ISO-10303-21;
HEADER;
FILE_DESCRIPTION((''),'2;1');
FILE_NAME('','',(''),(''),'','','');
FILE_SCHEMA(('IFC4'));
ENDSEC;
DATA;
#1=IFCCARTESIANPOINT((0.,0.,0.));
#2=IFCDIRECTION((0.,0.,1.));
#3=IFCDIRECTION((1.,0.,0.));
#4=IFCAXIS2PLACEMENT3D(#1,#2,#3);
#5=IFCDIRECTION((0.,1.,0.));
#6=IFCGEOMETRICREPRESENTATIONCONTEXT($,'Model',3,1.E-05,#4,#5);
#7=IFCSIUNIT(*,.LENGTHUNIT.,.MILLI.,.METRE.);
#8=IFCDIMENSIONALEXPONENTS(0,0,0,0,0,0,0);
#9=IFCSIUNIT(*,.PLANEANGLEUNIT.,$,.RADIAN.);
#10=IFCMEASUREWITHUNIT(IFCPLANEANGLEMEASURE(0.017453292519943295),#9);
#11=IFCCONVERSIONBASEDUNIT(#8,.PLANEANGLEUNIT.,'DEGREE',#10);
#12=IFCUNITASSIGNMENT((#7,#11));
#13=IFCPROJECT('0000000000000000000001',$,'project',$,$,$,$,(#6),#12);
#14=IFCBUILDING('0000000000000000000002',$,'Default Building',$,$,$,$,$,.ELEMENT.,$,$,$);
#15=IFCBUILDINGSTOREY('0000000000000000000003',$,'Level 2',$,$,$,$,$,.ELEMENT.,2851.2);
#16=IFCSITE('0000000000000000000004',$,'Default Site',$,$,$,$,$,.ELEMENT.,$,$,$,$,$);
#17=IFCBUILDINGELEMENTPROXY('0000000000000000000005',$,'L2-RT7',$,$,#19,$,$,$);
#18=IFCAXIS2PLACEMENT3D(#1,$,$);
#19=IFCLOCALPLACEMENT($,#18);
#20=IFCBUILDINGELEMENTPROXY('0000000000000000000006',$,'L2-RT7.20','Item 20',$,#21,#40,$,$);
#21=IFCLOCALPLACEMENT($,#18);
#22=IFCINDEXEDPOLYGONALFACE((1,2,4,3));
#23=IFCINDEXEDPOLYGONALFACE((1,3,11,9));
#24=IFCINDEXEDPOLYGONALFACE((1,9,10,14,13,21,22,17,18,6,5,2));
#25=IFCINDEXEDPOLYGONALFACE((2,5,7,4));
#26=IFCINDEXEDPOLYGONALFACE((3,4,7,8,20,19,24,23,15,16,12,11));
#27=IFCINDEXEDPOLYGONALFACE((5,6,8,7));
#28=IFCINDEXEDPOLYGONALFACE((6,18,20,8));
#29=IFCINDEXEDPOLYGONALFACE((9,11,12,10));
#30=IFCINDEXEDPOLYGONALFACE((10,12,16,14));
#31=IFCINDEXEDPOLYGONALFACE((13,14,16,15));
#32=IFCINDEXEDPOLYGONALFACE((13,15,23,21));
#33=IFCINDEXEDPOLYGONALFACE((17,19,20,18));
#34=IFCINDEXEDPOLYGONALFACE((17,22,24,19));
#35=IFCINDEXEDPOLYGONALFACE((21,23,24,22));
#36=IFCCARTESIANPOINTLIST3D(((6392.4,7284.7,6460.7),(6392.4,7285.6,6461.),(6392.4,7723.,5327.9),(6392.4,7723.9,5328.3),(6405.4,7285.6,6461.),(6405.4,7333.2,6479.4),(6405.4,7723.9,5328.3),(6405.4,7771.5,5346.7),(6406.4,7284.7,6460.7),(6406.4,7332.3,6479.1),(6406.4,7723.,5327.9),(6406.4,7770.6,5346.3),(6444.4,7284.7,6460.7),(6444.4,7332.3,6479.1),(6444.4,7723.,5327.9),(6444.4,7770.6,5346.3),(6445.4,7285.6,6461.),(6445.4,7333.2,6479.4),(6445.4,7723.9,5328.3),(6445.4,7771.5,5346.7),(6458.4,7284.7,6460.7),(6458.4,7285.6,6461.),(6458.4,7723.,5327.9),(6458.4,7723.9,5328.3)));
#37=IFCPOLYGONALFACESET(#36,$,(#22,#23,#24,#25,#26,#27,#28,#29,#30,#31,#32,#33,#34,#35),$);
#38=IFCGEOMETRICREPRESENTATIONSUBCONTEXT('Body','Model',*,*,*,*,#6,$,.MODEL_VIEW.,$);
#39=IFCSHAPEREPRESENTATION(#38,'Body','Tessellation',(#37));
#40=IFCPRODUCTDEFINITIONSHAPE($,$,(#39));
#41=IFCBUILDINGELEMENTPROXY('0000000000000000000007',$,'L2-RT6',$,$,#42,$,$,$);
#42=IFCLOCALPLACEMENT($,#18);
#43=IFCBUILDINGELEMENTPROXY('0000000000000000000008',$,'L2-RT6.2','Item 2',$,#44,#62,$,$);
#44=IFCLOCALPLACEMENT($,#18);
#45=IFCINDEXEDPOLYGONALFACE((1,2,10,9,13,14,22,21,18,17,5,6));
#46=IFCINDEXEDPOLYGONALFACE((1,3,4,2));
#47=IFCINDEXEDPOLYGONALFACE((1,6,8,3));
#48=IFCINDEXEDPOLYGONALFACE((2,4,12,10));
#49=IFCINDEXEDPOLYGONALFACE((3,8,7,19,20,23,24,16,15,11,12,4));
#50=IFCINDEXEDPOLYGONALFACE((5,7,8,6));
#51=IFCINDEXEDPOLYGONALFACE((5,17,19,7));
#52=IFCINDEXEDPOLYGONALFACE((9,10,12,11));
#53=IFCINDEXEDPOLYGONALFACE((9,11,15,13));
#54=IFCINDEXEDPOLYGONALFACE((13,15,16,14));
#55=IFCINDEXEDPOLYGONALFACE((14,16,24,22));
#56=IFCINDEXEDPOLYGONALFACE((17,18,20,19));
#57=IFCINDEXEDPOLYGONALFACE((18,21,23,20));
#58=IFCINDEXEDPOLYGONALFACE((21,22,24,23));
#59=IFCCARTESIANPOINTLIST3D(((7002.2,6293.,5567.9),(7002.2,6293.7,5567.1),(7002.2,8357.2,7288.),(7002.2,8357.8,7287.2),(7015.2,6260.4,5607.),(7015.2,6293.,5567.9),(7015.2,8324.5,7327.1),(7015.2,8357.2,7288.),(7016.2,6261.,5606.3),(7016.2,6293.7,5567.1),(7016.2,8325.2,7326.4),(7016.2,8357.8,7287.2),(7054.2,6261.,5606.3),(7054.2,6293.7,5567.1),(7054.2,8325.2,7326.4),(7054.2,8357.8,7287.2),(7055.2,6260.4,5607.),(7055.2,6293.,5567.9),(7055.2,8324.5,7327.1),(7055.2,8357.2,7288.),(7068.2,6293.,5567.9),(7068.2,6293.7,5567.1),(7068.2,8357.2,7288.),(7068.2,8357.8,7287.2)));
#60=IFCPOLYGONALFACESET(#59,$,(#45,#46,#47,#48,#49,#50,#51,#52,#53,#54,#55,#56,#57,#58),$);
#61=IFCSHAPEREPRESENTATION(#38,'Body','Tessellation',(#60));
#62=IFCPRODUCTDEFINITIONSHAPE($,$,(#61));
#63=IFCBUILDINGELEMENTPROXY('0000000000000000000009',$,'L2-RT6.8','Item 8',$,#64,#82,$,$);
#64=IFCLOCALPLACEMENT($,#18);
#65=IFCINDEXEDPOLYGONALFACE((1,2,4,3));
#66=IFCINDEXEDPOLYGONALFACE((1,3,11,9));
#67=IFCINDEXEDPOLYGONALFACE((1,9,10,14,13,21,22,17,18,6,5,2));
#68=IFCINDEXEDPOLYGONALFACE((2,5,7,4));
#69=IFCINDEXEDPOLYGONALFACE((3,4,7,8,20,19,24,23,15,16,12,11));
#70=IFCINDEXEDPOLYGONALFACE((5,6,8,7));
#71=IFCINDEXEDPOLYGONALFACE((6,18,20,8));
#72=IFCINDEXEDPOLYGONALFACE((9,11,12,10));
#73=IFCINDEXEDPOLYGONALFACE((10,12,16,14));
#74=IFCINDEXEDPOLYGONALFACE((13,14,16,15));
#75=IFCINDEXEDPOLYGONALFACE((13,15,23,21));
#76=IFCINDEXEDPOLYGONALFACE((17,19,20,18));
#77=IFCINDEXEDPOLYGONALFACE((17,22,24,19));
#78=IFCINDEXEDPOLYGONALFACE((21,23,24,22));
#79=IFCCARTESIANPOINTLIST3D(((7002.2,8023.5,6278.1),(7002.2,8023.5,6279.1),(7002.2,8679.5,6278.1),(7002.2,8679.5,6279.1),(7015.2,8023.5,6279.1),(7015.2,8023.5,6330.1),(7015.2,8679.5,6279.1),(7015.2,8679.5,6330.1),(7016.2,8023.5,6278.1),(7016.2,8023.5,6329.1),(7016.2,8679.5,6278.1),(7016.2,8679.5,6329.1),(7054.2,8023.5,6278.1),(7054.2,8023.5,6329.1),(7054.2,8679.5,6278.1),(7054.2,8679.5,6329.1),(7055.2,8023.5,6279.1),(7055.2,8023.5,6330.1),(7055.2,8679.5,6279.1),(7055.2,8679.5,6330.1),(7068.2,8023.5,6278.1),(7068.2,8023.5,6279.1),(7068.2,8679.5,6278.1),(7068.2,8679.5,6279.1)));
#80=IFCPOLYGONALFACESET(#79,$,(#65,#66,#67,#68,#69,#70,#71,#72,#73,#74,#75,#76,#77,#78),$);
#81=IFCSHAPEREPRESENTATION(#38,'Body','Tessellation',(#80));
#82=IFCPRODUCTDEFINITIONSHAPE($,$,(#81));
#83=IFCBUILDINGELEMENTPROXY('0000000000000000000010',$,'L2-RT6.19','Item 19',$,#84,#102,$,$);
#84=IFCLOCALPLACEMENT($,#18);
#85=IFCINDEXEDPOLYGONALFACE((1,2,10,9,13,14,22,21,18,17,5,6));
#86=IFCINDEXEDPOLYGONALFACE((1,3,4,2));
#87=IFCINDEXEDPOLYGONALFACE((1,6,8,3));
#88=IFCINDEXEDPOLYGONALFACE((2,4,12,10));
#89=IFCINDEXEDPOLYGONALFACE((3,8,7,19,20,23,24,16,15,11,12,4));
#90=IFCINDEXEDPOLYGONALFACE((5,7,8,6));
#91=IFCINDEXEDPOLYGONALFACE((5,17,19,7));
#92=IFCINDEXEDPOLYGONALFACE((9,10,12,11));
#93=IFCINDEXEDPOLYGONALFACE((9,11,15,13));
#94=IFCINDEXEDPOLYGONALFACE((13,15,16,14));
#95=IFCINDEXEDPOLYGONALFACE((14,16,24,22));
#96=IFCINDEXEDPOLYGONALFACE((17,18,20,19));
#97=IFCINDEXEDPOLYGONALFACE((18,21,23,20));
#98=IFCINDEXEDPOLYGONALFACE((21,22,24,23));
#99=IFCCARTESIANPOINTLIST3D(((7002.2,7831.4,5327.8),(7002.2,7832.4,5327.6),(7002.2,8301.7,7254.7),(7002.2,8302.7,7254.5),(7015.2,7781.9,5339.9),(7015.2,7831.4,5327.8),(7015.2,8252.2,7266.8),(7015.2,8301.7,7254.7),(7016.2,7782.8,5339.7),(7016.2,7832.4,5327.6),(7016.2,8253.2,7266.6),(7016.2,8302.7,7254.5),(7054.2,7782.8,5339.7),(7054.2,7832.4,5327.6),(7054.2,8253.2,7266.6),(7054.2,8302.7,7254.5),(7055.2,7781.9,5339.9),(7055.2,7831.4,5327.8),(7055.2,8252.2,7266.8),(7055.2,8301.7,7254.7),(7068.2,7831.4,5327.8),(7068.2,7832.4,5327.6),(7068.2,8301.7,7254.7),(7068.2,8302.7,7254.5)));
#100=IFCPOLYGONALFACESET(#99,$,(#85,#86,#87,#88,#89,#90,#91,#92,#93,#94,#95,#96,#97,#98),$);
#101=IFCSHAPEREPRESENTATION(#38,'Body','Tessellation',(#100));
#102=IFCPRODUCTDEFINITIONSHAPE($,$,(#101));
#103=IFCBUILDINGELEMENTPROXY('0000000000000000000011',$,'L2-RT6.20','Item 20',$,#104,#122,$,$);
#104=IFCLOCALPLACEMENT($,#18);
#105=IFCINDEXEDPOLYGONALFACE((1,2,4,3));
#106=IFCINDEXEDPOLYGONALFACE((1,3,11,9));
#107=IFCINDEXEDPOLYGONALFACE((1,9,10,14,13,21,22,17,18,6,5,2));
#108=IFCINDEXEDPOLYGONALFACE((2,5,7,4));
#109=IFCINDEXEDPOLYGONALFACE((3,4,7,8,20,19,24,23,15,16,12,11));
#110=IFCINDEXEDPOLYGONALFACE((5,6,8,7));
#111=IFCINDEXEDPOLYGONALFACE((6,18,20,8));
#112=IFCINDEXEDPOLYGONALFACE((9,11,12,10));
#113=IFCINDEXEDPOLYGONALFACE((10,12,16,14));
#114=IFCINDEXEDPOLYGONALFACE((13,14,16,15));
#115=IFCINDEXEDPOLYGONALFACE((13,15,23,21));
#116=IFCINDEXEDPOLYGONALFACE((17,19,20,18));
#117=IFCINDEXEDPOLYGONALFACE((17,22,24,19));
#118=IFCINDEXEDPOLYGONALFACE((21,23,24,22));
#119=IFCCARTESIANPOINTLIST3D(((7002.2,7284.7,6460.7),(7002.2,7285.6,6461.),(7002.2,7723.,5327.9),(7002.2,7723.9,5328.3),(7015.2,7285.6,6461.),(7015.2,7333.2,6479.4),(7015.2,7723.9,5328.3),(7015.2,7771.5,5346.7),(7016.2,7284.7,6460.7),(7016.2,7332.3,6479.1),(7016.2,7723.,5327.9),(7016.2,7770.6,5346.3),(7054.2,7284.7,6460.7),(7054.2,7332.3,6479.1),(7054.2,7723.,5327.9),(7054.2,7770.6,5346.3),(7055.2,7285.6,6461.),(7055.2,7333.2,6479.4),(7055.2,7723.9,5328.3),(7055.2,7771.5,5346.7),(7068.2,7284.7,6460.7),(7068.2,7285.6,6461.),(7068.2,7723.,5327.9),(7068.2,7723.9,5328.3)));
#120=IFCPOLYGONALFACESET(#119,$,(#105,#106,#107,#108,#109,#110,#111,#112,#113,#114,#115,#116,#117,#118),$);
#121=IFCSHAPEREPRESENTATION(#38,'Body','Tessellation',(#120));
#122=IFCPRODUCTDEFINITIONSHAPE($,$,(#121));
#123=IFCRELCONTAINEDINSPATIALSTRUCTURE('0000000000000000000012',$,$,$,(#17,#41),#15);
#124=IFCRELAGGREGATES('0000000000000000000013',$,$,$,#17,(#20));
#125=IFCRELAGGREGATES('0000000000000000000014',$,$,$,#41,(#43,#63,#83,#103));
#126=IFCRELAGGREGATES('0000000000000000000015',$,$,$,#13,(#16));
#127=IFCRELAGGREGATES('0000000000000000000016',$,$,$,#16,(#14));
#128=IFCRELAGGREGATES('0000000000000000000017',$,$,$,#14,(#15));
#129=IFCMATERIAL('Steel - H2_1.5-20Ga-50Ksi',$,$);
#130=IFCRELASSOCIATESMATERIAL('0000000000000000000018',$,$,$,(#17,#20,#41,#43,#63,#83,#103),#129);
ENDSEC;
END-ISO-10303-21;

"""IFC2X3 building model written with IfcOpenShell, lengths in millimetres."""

from ifc_helpers import new_model, entity, si_unit, converted_unit, direction, frame, origin, origin_with_axes, place, context, subcontext, project, spatial, polyline, outline, extrude, material, element, aggregate, save


model = new_model("IFC2X3")

# Units and contexts
model_context = context("Model", 3, precision=1e-05, world=origin_with_axes(), true_north=direction((0.0, 1.0, 0.0)))
body_context = subcontext(model_context, "Body", "Model", "MODEL_VIEW")
ifc_project = project(units=[si_unit("LENGTHUNIT", "METRE", prefix="MILLI"), converted_unit("PLANEANGLEUNIT", "DEGREE", entity("IfcPlaneAngleMeasure", 0.017453292519943295), si_unit("PLANEANGLEUNIT", "RADIAN"), dimensions=[0, 0, 0, 0, 0, 0, 0])], contexts=[model_context])

# Site, building, storey
site = spatial("IfcSite", under=ifc_project, Name="Default Site", CompositionType="ELEMENT")
building = spatial("IfcBuilding", under=site, Name="Default Building", CompositionType="ELEMENT")
storey = spatial("IfcBuildingStorey", under=building, Name="Level 2", CompositionType="ELEMENT", Elevation=2851.2)

# Building element proxies
ifc_material_1 = material(Name="Steel - H2_1.5-20Ga-50Ksi")
proxy_1 = element("IfcBuildingElementProxy", 1, inside=storey, material=ifc_material_1, Name="L2-RT7")
proxy_2_placement = place(None, frame((6392.4, 7723.0, 5327.9), z_axis=(0.0, -0.361, 0.933), x_axis=(40.0, 0.0, 0.0)))
proxy_2 = element("IfcBuildingElementProxy", 2, at=proxy_2_placement, material=ifc_material_1, Name="L2-RT7.20", Description="Item 20", context=body_context, shape_type="SweptSolid", body=[
    extrude(outline(polyline([(0.0, 0.0), (14.0, 0.0), (14.0, 51.0), (52.0, 51.0), (52.0, 0.0), (66.0, 0.0), (66.0, 1.0), (53.0, 1.0), (53.0, 52.0), (13.0, 52.0), (13.0, 1.0), (0.0, 1.0), (0.0, 0.0)])), origin(), (0.0, 0.0, 1.0), 1214.6),
])
aggregate(proxy_1, [proxy_2])
proxy_3 = element("IfcBuildingElementProxy", 3, inside=storey, material=ifc_material_1, Name="L2-RT6")
proxy_4_placement = place(None, frame((7002.2, 8357.8, 7287.2), z_axis=(0.0, -0.768, -0.64), x_axis=(40.0, 0.0, 0.0)))
proxy_4 = element("IfcBuildingElementProxy", 4, at=proxy_4_placement, material=ifc_material_1, Name="L2-RT6.2", Description="Item 2", context=body_context, shape_type="SweptSolid", body=[
    extrude(outline(polyline([(0.0, 0.0), (14.0, 0.0), (14.0, 51.0), (52.0, 51.0), (52.0, 0.0), (66.0, 0.0), (66.0, 1.0), (53.0, 1.0), (53.0, 52.0), (13.0, 52.0), (13.0, 1.0), (0.0, 1.0), (0.0, 0.0)])), origin(), (0.0, 0.0, 1.0), 2686.9),
])
proxy_5_placement = place(None, frame((7002.2, 8679.5, 6278.1), z_axis=(0.0, -1.0, 0.0), x_axis=(40.0, 0.0, 0.0)))
proxy_5 = element("IfcBuildingElementProxy", 5, at=proxy_5_placement, material=ifc_material_1, Name="L2-RT6.8", Description="Item 8", context=body_context, shape_type="SweptSolid", body=[
    extrude(outline(polyline([(0.0, 0.0), (14.0, 0.0), (14.0, 51.0), (52.0, 51.0), (52.0, 0.0), (66.0, 0.0), (66.0, 1.0), (53.0, 1.0), (53.0, 52.0), (13.0, 52.0), (13.0, 1.0), (0.0, 1.0), (0.0, 0.0)])), origin(), (0.0, 0.0, 1.0), 656.0),
])
proxy_6_placement = place(None, frame((7002.2, 8302.7, 7254.5), z_axis=(0.0, -0.237, -0.971), x_axis=(40.0, 0.0, 0.0)))
proxy_6 = element("IfcBuildingElementProxy", 6, at=proxy_6_placement, material=ifc_material_1, Name="L2-RT6.19", Description="Item 19", context=body_context, shape_type="SweptSolid", body=[
    extrude(outline(polyline([(0.0, 0.0), (14.0, 0.0), (14.0, 51.0), (52.0, 51.0), (52.0, 0.0), (66.0, 0.0), (66.0, 1.0), (53.0, 1.0), (53.0, 52.0), (13.0, 52.0), (13.0, 1.0), (0.0, 1.0), (0.0, 0.0)])), origin(), (0.0, 0.0, 1.0), 1983.5),
])
proxy_7_placement = place(None, frame((7002.2, 7723.0, 5327.9), z_axis=(0.0, -0.361, 0.933), x_axis=(40.0, 0.0, 0.0)))
proxy_7 = element("IfcBuildingElementProxy", 7, at=proxy_7_placement, material=ifc_material_1, Name="L2-RT6.20", Description="Item 20", context=body_context, shape_type="SweptSolid", body=[
    extrude(outline(polyline([(0.0, 0.0), (14.0, 0.0), (14.0, 51.0), (52.0, 51.0), (52.0, 0.0), (66.0, 0.0), (66.0, 1.0), (53.0, 1.0), (53.0, 52.0), (13.0, 52.0), (13.0, 1.0), (0.0, 1.0), (0.0, 0.0)])), origin(), (0.0, 0.0, 1.0), 1214.6),
])
aggregate(proxy_3, [proxy_4, proxy_5, proxy_6, proxy_7])

save(model, "model.ifc")
